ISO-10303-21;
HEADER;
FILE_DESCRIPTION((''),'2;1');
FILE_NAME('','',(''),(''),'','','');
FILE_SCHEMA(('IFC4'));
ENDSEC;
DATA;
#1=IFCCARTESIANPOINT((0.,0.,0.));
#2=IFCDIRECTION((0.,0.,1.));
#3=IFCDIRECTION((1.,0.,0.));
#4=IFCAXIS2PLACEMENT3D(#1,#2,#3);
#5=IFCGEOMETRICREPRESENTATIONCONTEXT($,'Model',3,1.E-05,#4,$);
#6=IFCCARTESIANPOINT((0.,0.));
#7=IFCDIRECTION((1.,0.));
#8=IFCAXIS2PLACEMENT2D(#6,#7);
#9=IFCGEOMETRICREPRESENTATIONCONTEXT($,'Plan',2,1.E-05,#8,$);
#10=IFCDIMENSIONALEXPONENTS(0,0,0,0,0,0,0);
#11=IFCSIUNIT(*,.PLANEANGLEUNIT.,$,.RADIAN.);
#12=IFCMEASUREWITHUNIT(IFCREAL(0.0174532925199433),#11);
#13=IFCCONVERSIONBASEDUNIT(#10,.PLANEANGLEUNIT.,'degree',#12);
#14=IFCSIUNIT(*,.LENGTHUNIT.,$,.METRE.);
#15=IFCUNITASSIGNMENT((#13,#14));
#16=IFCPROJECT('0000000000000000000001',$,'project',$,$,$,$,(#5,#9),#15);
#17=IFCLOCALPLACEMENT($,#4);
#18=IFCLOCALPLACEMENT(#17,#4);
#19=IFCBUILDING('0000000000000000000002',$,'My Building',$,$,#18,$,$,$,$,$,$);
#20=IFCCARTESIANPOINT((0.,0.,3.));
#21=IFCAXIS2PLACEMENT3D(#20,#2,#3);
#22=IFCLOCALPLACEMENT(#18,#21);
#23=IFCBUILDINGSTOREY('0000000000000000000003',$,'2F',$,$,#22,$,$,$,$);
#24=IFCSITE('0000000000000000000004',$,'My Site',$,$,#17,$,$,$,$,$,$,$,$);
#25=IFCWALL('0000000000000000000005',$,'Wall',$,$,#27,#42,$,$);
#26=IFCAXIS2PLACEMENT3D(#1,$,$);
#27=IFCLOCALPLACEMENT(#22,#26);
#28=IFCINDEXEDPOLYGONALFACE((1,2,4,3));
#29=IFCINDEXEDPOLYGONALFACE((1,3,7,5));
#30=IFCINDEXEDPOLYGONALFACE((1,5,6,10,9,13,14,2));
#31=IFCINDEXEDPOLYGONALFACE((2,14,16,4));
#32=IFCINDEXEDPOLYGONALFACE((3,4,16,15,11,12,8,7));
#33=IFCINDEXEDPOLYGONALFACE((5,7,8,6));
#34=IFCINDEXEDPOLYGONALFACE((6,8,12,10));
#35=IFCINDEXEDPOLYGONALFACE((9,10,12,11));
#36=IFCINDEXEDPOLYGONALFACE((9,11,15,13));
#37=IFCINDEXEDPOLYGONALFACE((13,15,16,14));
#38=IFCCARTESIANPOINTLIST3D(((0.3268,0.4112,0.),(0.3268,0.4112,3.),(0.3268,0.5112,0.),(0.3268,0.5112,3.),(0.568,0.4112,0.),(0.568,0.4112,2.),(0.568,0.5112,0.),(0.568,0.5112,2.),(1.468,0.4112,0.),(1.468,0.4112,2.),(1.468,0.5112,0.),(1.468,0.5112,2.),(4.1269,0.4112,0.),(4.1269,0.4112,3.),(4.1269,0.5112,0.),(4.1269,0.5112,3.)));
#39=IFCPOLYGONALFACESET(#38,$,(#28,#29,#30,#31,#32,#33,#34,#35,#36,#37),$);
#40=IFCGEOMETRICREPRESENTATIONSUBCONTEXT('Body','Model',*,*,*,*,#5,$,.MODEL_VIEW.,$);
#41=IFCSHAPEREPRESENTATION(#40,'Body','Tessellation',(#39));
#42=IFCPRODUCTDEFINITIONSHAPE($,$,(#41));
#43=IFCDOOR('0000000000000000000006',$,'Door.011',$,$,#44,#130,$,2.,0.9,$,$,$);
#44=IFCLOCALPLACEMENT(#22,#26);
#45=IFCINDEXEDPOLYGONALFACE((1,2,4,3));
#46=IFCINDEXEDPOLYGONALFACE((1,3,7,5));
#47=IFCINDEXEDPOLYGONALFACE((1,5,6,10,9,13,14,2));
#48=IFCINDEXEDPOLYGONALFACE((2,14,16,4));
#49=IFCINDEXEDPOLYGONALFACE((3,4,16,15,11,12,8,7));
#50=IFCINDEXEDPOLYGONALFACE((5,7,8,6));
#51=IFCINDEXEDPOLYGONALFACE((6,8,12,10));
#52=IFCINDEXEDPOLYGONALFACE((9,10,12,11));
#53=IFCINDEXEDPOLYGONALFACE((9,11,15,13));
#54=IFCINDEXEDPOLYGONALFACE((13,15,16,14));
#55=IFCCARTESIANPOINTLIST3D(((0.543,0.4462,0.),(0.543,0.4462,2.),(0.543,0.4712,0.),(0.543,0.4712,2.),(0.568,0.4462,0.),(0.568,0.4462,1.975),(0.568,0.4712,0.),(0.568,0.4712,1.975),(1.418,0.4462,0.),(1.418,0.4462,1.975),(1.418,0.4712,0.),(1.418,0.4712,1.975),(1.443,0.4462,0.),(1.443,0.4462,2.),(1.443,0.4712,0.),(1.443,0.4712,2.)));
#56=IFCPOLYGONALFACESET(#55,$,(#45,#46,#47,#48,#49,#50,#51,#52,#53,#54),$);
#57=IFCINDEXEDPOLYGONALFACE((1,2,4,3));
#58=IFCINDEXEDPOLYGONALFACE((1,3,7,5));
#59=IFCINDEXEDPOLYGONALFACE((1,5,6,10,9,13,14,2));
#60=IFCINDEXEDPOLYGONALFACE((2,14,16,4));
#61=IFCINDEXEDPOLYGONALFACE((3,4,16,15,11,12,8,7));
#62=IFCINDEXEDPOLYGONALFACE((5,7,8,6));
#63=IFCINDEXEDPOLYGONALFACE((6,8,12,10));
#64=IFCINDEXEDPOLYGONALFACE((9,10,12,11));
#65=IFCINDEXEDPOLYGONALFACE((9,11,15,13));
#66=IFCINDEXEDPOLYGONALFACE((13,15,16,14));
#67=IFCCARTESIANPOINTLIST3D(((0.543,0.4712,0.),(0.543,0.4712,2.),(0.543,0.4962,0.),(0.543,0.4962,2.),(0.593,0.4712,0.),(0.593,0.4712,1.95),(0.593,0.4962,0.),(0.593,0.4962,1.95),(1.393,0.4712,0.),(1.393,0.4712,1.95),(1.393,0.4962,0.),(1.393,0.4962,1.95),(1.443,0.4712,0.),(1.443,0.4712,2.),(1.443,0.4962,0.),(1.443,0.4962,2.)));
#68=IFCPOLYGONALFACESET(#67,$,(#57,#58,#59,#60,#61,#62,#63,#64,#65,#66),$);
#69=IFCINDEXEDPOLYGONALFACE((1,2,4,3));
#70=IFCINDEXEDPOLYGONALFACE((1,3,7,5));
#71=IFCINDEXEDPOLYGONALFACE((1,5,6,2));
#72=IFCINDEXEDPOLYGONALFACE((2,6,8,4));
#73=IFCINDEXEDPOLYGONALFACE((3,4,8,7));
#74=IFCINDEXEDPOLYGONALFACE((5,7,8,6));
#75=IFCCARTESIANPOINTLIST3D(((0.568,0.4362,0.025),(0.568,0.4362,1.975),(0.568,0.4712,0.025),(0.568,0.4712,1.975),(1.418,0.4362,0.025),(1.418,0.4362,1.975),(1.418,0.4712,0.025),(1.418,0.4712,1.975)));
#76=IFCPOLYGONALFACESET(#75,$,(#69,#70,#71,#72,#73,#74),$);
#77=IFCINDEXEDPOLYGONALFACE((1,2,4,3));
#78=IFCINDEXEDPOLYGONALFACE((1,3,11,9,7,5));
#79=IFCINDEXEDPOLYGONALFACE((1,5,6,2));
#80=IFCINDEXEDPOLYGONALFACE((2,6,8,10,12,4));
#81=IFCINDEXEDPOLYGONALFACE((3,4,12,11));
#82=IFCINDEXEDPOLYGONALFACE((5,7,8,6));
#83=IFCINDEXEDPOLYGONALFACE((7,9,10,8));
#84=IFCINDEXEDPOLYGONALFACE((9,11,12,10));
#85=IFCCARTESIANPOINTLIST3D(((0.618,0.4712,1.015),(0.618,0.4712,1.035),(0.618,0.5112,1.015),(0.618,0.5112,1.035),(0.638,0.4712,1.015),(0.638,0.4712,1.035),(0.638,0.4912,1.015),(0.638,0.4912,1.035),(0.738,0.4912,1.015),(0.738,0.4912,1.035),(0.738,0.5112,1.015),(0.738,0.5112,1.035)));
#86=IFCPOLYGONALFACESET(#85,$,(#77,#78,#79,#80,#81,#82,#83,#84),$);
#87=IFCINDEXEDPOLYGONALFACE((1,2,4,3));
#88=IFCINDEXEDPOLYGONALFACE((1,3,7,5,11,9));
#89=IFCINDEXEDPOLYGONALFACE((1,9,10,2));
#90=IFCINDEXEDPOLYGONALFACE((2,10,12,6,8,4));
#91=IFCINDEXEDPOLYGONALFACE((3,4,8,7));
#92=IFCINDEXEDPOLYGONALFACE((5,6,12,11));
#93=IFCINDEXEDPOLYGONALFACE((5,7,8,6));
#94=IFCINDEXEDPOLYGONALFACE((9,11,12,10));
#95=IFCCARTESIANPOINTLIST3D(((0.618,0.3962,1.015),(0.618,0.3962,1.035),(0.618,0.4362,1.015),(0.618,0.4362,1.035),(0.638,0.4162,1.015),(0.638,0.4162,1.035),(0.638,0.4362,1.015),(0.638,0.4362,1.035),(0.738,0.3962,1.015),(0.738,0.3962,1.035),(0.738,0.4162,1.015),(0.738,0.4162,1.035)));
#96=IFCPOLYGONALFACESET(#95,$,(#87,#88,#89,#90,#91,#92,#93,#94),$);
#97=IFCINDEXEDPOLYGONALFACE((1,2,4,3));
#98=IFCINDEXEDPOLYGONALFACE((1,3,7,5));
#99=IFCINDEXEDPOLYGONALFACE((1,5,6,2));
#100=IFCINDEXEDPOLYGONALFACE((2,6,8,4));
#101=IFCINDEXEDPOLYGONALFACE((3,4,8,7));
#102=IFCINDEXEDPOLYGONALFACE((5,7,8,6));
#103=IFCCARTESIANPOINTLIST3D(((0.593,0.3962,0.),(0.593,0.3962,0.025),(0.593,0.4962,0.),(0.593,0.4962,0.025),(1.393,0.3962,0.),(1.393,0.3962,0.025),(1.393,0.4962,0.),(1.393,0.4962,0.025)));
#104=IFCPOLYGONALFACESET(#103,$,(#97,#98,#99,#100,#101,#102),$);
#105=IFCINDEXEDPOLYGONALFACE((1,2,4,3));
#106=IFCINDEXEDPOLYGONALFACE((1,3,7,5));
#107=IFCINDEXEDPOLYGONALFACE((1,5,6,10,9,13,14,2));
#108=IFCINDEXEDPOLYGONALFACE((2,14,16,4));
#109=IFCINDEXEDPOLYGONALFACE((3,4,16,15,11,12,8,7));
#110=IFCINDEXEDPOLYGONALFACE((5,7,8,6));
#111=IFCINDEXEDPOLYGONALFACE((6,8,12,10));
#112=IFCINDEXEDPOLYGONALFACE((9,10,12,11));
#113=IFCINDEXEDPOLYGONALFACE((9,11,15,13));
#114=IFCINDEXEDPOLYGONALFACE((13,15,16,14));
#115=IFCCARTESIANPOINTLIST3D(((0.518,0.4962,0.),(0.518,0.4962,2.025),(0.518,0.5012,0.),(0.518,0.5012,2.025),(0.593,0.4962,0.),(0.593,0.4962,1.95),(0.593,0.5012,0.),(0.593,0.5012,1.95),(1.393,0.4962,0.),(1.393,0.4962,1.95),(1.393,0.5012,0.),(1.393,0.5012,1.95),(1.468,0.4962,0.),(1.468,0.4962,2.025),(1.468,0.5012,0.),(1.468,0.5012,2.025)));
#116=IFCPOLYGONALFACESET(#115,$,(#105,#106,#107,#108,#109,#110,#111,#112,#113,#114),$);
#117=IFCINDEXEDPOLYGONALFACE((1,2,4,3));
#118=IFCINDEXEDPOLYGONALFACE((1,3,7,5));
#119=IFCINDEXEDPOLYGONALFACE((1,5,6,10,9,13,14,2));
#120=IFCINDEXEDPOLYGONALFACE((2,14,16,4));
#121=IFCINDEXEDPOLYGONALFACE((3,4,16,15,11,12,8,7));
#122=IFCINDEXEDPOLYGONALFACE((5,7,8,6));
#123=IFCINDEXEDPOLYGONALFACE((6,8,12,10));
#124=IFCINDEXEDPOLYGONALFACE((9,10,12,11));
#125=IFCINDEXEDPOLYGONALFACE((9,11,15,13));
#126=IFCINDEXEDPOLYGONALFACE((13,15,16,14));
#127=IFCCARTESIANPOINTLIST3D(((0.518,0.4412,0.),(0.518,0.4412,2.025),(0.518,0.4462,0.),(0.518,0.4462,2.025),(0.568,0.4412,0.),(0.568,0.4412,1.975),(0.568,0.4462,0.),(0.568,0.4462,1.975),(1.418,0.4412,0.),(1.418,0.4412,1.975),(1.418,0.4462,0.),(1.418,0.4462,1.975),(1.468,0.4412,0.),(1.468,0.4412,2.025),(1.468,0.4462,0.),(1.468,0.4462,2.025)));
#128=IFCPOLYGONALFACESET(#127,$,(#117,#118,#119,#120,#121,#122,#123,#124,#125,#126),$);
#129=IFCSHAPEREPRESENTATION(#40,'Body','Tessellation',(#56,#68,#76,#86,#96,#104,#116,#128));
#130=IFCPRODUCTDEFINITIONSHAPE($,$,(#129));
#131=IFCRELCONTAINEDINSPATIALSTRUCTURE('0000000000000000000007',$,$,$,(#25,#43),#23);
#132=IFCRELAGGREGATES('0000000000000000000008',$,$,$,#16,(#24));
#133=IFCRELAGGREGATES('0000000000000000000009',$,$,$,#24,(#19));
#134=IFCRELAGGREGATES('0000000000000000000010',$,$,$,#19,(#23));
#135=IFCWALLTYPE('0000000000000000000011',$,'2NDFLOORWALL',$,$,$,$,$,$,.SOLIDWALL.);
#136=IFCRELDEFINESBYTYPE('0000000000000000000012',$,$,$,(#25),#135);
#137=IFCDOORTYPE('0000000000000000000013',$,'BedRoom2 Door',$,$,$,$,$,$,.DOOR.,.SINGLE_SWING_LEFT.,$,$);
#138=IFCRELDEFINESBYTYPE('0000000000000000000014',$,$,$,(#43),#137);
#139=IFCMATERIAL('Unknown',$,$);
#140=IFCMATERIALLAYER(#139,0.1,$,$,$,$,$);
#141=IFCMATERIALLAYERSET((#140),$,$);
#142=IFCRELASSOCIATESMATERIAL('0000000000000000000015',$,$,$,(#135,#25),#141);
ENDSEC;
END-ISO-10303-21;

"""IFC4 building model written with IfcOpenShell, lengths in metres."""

from ifc_helpers import new_model, entity, si_unit, converted_unit, frame, origin_with_axes, origin_2d_with_axis, place, context, subcontext, project, spatial, line, indexed_curve, outline, extrude, shape, source, transform, mapped, material, layer, layer_set, layer_usage, type_object, type_shapes, element, fill, save


model = new_model("IFC4")

# Units and contexts
model_context = context("Model", 3, precision=1e-05, world=origin_with_axes())
plan_context = context("Plan", 2, precision=1e-05, world=origin_2d_with_axis())
body_context_1 = subcontext(model_context, "Body", "Model", "MODEL_VIEW")
body_context_2 = subcontext(plan_context, "Body", "Plan", "PLAN_VIEW")
ifc_project = project(units=[converted_unit("PLANEANGLEUNIT", "degree", entity("IfcReal", 0.0174532925199433), si_unit("PLANEANGLEUNIT", "RADIAN"), dimensions=[0, 0, 0, 0, 0, 0, 0]), si_unit("LENGTHUNIT", "METRE")], contexts=[model_context, plan_context])

# Site, building, storey
site_placement = place(None, origin_with_axes())
site = spatial("IfcSite", under=ifc_project, at=site_placement, Name="My Site")
building_placement = place(site_placement, origin_with_axes())
building = spatial("IfcBuilding", under=site, at=building_placement, Name="My Building")
storey_placement = place(building_placement, frame((0.0, 0.0, 3.0), z_axis=(0.0, 0.0, 1.0), x_axis=(1.0, 0.0, 0.0)))
storey = spatial("IfcBuildingStorey", under=building, at=storey_placement, Name="2F")

# Shared definitions
ifc_material = material(Name="Unknown")

# Shared definitions
ifc_layer_1 = layer(ifc_material, 0.1)
ifc_layer_set_1 = layer_set([ifc_layer_1])
wall_type_1 = type_object("IfcWallType", Name="2NDFLOORWALL", PredefinedType="SOLIDWALL", material=ifc_layer_set_1)

# Wall, opening, door
ifc_layer_usage_1 = layer_usage(ifc_layer_set_1, "AXIS2", "POSITIVE", 0.0)
wall_1_placement = place(storey_placement, frame((0.3268, 0.4112, 0.0), z_axis=(0.0, 0.0, 1.0), x_axis=(1.0, 0.0, 0.0)))
wall_1 = element("IfcWall", 1, at=wall_1_placement, inside=storey, type_object=wall_type_1, material=ifc_layer_usage_1, Name="Wall", context=body_context_1, shape_type="SweptSolid", body=[
    extrude(outline(indexed_curve([(0.0, 0.0), (0.0, 0.1), (3.8001, 0.1), (3.8001, 0.0)], segments=[line(1, 2, 3, 4, 1)])), origin_with_axes(), (0.0, 0.0, 1.0), 3.0),
])
shared_shape_1 = source(origin_with_axes(), body_context_1, "Body", "SweptSolid", [
    extrude(outline(indexed_curve([(0.0, 0.0), (0.9, 0.0), (0.9, 2.0), (0.0, 2.0)], segments=[line(1, 2, 3, 4, 1)])), frame((0.0, -0.6, 0.0), z_axis=(0.0, -1.0, 0.0), x_axis=(1.0, 0.0, 0.0)), (0.0, 0.0, -1.0), 1.2),
])
opening_1_placement = place(wall_1_placement, frame((0.2412, 0.0, 0.0), z_axis=(0.0, 0.0, 1.0), x_axis=(1.0, 0.0, 0.0)))
opening_1 = element("IfcOpeningElement", 2, at=opening_1_placement, cuts=wall_1, PredefinedType="OPENING", context=body_context_1, shape_type="MappedRepresentation", body=[
    mapped(shared_shape_1, transform((0.0, 0.0, 0.0), x_axis=(1.0, 0.0, 0.0), y_axis=(0.0, 1.0, 0.0), z_axis=(0.0, 0.0, 1.0), scale=1.0)),
])
door_type_1 = type_object("IfcDoorType", Name="BedRoom2 Door", OperationType="SINGLE_SWING_LEFT", PredefinedType="DOOR")
shared_shape_2 = source(origin_with_axes(), body_context_1, "Body", "SweptSolid", [
    extrude(outline(indexed_curve([(0.0, 0.0), (0.0, 2.0), (0.9, 2.0), (0.9, 0.0), (0.875, 0.0), (0.875, 1.975), (0.025, 1.975), (0.025, 0.0)], segments=[line(1, 2, 3, 4, 5, 6, 7, 8, 1)])), frame((0.0, 0.025, 0.0), z_axis=(0.0, -1.0, 0.0), x_axis=(1.0, 0.0, 0.0)), (0.0, 0.0, -1.0), 0.025),
    extrude(outline(indexed_curve([(0.0, 0.0), (0.0, 2.0), (0.9, 2.0), (0.9, 0.0), (0.85, 0.0), (0.85, 1.95), (0.05, 1.95), (0.05, 0.0)], segments=[line(1, 2, 3, 4, 5, 6, 7, 8, 1)])), frame((0.0, 0.0, 0.0), z_axis=(0.0, -1.0, 0.0), x_axis=(1.0, 0.0, 0.0)), (0.0, 0.0, -1.0), 0.025),
    extrude(outline(indexed_curve([(0.0, 0.0), (0.85, 0.0), (0.85, 0.035), (0.0, 0.035)], segments=[line(1, 2, 3, 4, 1)])), frame((0.025, 0.025, 0.025), z_axis=(0.0, 0.0, 1.0), x_axis=(1.0, 0.0, 0.0)), (0.0, 0.0, 1.0), 1.95),
    extrude(outline(indexed_curve([(0.0, 0.0), (0.0, -0.04), (-0.12, -0.04), (-0.12, -0.02), (-0.02, -0.02), (-0.02, 0.0)], segments=[line(1, 2, 3, 4, 5, 6, 1)])), frame((0.825, 0.025, 1.015), z_axis=(0.0, 0.0, 1.0), x_axis=(1.0, 0.0, 0.0)), (0.0, 0.0, 1.0), 0.02),
    extrude(outline(indexed_curve([(0.0, 0.0), (0.0, 0.04), (-0.12, 0.04), (-0.12, 0.02), (-0.02, 0.02), (-0.02, 0.0)], segments=[line(1, 2, 3, 4, 5, 6, 1)])), frame((0.825, 0.06, 1.015), z_axis=(0.0, 0.0, 1.0), x_axis=(1.0, 0.0, 0.0)), (0.0, 0.0, 1.0), 0.02),
    extrude(outline(indexed_curve([(0.0, 0.0), (0.8, 0.0), (0.8, 0.1), (0.0, 0.1)], segments=[line(1, 2, 3, 4, 1)])), frame((0.05, 0.0, 0.0), z_axis=(0.0, 0.0, 1.0), x_axis=(1.0, 0.0, 0.0)), (0.0, 0.0, 1.0), 0.025),
    extrude(outline(indexed_curve([(0.0, 0.0), (0.0, 2.025), (0.95, 2.025), (0.95, 0.0), (0.875, 0.0), (0.875, 1.95), (0.075, 1.95), (0.075, 0.0)], segments=[line(1, 2, 3, 4, 5, 6, 7, 8, 1)])), frame((-0.025, -0.005, 0.0), z_axis=(0.0, -1.0, 0.0), x_axis=(1.0, 0.0, 0.0)), (0.0, 0.0, -1.0), 0.005),
    extrude(outline(indexed_curve([(0.0, 0.0), (0.0, 2.025), (0.95, 2.025), (0.95, 0.0), (0.9, 0.0), (0.9, 1.975), (0.05, 1.975), (0.05, 0.0)], segments=[line(1, 2, 3, 4, 5, 6, 7, 8, 1)])), frame((-0.025, 0.05, 0.0), z_axis=(0.0, -1.0, 0.0), x_axis=(1.0, 0.0, 0.0)), (0.0, 0.0, -1.0), 0.005),
])
shared_shape_3 = source(origin_with_axes(), body_context_2, "Body", "Curve2D", [
    entity("IfcIndexedPolyCurve", entity("IfcCartesianPointList2D", [[0.0, 0.0], [0.0, 0.05], [0.025, 0.05], [0.025, 0.025], [0.05, 0.025], [0.05, 0.0]]), [entity("IfcLineIndex", [1, 2, 3, 4, 5, 6, 1])]),
    entity("IfcIndexedPolyCurve", entity("IfcCartesianPointList2D", [[0.9, 0.0], [0.9, 0.05], [0.875, 0.05], [0.875, 0.025], [0.85, 0.025], [0.85, 0.0]]), [entity("IfcLineIndex", [1, 2, 3, 4, 5, 6, 1])]),
    entity("IfcTrimmedCurve", entity("IfcEllipse", entity("IfcAxis2Placement2D", entity("IfcCartesianPoint", [0.06, 0.05]), entity("IfcDirection", [1.0, 0.0])), 0.815, 0.85), [entity("IfcCartesianPoint", [0.875, 0.05])], [entity("IfcCartesianPoint", [0.06, 0.9])], True, "CARTESIAN"),
    entity("IfcIndexedPolyCurve", entity("IfcCartesianPointList2D", [[0.025, 0.05], [0.06, 0.05], [0.06, 0.9], [0.025, 0.9]]), [entity("IfcLineIndex", [1, 2, 3, 4, 1])]),
])
type_shapes(door_type_1, [shared_shape_2, shared_shape_3])
door_1_placement = place(opening_1_placement, frame((0.875, 0.085, 0.0), z_axis=(0.0, 0.0, 1.0), x_axis=(-1.0, 0.0, 0.0)))
door_1 = element("IfcDoor", 3, at=door_1_placement, inside=storey, type_object=door_type_1, Name="Door.011", OverallHeight=2.0, OverallWidth=0.9, shapes=[
    shape(body_context_1, "Body", "MappedRepresentation", [mapped(shared_shape_2, transform((0.0, 0.0, 0.0), x_axis=(1.0, 0.0, 0.0), y_axis=(0.0, 1.0, 0.0), z_axis=(0.0, 0.0, 1.0), scale=1.0))]),
    shape(body_context_2, "Body", "MappedRepresentation", [mapped(shared_shape_3, transform((0.0, 0.0, 0.0), x_axis=(1.0, 0.0, 0.0), y_axis=(0.0, 1.0, 0.0), z_axis=(0.0, 0.0, 1.0), scale=1.0))]),
])
fill(opening_1, door_1)

save(model, "model.ifc")
